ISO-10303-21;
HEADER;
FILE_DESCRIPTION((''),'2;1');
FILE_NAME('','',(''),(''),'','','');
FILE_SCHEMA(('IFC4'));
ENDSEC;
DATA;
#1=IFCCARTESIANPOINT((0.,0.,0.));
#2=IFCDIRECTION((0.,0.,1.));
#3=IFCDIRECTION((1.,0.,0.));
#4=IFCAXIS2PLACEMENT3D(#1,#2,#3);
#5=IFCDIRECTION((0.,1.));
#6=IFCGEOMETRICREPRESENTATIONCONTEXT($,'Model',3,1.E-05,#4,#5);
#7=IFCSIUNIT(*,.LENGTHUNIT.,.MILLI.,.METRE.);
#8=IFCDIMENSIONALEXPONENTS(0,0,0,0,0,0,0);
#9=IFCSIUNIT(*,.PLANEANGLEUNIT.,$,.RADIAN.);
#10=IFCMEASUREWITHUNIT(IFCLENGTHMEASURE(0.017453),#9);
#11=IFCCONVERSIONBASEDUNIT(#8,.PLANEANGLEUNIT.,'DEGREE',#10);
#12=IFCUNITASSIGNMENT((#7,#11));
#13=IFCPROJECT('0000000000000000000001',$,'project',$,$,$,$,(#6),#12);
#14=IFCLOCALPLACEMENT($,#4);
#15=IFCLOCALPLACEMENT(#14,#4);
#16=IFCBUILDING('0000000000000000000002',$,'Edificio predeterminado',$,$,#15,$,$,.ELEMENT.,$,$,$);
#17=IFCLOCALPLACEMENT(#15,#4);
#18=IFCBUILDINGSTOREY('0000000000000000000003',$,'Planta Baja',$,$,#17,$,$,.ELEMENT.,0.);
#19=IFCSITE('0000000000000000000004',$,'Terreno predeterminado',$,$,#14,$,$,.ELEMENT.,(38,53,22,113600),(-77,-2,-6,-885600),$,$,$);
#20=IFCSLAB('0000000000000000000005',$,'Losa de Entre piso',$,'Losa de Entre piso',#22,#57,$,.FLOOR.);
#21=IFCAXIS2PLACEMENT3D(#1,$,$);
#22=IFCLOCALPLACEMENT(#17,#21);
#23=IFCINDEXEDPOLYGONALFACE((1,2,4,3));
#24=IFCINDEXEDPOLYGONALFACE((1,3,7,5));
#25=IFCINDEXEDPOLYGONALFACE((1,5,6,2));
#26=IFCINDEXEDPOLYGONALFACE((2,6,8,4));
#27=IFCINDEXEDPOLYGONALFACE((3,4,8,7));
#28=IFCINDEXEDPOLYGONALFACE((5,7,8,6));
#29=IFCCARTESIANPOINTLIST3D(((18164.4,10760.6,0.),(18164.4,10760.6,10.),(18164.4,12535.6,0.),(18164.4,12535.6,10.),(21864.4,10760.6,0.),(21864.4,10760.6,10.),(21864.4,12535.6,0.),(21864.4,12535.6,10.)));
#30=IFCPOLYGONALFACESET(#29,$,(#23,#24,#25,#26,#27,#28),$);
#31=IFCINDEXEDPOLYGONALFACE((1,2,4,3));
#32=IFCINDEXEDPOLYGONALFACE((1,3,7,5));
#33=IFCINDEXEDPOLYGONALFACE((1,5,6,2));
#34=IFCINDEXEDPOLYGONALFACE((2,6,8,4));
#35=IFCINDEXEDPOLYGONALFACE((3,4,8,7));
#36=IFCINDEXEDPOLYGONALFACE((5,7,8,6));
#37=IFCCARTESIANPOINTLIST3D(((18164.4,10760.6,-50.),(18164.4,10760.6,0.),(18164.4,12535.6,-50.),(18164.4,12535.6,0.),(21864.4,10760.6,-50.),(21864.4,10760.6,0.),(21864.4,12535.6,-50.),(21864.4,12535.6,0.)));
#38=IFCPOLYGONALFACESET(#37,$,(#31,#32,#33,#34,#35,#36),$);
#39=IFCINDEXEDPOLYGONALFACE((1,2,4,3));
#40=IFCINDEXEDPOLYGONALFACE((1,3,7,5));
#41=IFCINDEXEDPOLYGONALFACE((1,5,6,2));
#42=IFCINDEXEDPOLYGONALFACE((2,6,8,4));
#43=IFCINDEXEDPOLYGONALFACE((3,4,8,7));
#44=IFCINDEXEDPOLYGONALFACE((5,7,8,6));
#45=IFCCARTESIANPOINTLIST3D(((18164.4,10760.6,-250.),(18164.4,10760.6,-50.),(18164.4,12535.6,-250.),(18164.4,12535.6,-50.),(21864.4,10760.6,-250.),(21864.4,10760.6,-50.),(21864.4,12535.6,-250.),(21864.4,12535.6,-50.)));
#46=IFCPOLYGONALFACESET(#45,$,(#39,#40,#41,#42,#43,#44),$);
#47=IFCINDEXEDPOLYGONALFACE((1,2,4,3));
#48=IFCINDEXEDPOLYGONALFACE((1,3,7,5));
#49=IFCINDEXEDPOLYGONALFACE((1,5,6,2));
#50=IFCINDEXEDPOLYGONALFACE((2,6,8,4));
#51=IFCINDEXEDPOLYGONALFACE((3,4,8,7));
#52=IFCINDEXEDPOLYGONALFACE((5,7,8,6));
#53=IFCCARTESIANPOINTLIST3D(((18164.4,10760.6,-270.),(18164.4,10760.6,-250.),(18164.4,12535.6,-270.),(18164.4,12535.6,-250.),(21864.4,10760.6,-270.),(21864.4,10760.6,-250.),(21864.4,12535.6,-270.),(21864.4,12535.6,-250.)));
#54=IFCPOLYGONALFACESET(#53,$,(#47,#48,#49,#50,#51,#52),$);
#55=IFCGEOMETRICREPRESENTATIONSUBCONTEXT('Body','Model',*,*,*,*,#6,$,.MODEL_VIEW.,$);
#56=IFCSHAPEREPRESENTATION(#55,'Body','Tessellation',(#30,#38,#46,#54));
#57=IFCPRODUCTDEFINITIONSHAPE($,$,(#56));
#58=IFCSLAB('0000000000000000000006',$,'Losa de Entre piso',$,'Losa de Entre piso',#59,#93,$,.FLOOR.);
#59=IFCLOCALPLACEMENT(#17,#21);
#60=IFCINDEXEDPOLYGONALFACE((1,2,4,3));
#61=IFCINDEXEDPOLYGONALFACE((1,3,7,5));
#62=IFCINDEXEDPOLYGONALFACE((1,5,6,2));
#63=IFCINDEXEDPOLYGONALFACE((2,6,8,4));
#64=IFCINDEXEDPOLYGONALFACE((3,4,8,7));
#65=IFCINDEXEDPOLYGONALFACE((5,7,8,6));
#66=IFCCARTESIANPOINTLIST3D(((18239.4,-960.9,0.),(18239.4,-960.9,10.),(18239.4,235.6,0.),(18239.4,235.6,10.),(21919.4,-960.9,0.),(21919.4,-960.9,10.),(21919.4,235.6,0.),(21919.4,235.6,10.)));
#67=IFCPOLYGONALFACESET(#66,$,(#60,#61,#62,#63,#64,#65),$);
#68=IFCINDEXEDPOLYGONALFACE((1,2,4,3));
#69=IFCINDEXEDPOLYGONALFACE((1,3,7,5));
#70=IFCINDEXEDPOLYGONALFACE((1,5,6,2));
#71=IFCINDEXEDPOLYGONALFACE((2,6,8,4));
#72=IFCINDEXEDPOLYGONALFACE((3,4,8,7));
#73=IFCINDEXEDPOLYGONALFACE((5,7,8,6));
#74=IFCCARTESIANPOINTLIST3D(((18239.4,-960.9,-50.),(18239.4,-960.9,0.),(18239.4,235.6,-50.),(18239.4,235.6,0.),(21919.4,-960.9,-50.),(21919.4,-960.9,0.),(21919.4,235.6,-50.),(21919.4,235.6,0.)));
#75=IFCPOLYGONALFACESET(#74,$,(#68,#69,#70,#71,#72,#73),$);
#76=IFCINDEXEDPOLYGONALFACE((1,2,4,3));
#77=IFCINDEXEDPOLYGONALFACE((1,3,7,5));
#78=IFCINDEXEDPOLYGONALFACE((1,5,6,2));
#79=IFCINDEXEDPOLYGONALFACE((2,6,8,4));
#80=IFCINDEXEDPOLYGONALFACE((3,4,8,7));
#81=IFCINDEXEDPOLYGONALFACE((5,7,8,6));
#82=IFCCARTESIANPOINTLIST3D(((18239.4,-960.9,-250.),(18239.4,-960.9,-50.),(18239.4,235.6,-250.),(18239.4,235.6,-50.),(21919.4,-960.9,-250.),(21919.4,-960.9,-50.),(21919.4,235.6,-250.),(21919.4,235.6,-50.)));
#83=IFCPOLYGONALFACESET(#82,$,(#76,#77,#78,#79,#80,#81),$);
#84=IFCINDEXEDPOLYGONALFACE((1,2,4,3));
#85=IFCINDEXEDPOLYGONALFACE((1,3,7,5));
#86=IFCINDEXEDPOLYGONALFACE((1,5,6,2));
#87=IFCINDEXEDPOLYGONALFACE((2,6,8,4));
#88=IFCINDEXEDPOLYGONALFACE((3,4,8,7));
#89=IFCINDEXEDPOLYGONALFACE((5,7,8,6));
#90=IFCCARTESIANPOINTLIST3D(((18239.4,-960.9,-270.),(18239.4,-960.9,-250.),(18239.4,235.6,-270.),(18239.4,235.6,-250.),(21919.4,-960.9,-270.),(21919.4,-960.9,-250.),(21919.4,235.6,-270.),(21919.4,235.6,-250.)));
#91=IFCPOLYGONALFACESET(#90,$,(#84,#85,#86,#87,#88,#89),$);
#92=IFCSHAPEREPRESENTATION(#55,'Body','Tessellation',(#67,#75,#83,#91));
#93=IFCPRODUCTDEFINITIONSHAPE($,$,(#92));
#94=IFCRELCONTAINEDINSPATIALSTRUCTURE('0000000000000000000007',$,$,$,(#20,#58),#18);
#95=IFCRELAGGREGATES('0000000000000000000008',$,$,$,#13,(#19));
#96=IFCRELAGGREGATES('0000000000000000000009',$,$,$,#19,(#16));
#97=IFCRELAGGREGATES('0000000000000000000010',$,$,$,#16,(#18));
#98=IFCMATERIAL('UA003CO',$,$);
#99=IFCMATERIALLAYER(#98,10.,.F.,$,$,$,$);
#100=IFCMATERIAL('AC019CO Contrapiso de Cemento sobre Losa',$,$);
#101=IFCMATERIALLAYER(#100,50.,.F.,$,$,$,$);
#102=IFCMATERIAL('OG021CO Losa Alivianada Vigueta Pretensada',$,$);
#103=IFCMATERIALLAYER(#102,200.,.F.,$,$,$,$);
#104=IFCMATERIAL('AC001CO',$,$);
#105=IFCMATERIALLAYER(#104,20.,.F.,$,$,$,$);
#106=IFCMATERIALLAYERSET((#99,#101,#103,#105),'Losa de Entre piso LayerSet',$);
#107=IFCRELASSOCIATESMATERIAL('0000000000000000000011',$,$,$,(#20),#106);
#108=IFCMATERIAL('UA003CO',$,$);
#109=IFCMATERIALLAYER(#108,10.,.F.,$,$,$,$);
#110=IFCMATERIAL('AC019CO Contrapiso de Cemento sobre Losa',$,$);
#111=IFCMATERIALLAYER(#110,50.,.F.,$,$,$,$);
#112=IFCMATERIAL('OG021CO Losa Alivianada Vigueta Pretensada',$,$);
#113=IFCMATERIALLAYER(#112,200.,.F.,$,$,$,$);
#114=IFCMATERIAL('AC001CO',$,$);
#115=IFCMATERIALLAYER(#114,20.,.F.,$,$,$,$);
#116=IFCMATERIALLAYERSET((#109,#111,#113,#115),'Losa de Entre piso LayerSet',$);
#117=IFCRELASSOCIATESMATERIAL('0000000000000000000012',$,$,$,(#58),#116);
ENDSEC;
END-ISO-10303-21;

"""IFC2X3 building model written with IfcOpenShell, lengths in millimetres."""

from ifc_helpers import new_model, entity, si_unit, converted_unit, direction, frame, origin_with_axes, place, context, subcontext, project, spatial, polyline, outline, extrude, material, layer, layer_set, layer_usage, element, save


model = new_model("IFC2X3")

# Units and contexts
model_context = context("Model", 3, precision=1e-05, world=origin_with_axes(), true_north=direction((0.0, 1.0)))
body_context = subcontext(model_context, "Body", "Model", "MODEL_VIEW")
ifc_project = project(units=[si_unit("LENGTHUNIT", "METRE", prefix="MILLI"), converted_unit("PLANEANGLEUNIT", "DEGREE", entity("IfcLengthMeasure", 0.017453), si_unit("PLANEANGLEUNIT", "RADIAN"), dimensions=[0, 0, 0, 0, 0, 0, 0])], contexts=[model_context])

# Site, building, storey
site_placement = place(None, origin_with_axes())
site = spatial("IfcSite", under=ifc_project, at=site_placement, Name="Terreno predeterminado", CompositionType="ELEMENT", RefLatitude=(38, 53, 22, 113600), RefLongitude=(-77, -2, -6, -885600))
building_placement = place(site_placement, origin_with_axes())
building = spatial("IfcBuilding", under=site, at=building_placement, Name="Edificio predeterminado", CompositionType="ELEMENT")
storey_placement = place(building_placement, origin_with_axes())
storey = spatial("IfcBuildingStorey", under=building, at=storey_placement, Name="Planta Baja", CompositionType="ELEMENT", Elevation=0.0)

# Slabs
ifc_material_1 = material(Name="UA003CO")
ifc_layer_1 = layer(ifc_material_1, 10.0, ventilated=False)
ifc_material_2 = material(Name="AC019CO Contrapiso de Cemento sobre Losa")
ifc_layer_2 = layer(ifc_material_2, 50.0, ventilated=False)
ifc_material_3 = material(Name="OG021CO Losa Alivianada Vigueta Pretensada")
ifc_layer_3 = layer(ifc_material_3, 200.0, ventilated=False)
ifc_material_4 = material(Name="AC001CO")
ifc_layer_4 = layer(ifc_material_4, 20.0, ventilated=False)
ifc_layer_set_1 = layer_set([ifc_layer_1, ifc_layer_2, ifc_layer_3, ifc_layer_4], Name="Losa de Entre piso LayerSet")
ifc_layer_usage_1 = layer_usage(ifc_layer_set_1, "AXIS3", "POSITIVE", 0.0)
slab_1_placement = place(storey_placement, origin_with_axes())
element("IfcSlab", 1, at=slab_1_placement, inside=storey, material=ifc_layer_usage_1, Name="Losa de Entre piso", ObjectType="Losa de Entre piso", PredefinedType="FLOOR", context=body_context, shape_type="SweptSolid", body=[
    extrude(outline(polyline([(0.0, 0.0), (1775.0, 0.0), (1775.0, 3700.0), (0.0, 3700.0), (0.0, 0.0)])), frame((21864.4, 12535.6, 0.0), z_axis=(0.0, 0.0, -1.0), x_axis=(0.0, -1.0, 0.0)), (0.0, 0.0, -1.0), 10.0),
    extrude(outline(polyline([(0.0, 0.0), (1775.0, 0.0), (1775.0, 3700.0), (0.0, 3700.0), (0.0, 0.0)])), frame((21864.4, 12535.6, -50.0), z_axis=(0.0, 0.0, -1.0), x_axis=(0.0, -1.0, 0.0)), (0.0, 0.0, -1.0), 50.0),
    extrude(outline(polyline([(0.0, 0.0), (1775.0, 0.0), (1775.0, 3700.0), (0.0, 3700.0), (0.0, 0.0)])), frame((21864.4, 12535.6, -250.0), z_axis=(0.0, 0.0, -1.0), x_axis=(0.0, -1.0, 0.0)), (0.0, 0.0, -1.0), 200.0),
    extrude(outline(polyline([(0.0, 0.0), (1775.0, 0.0), (1775.0, 3700.0), (0.0, 3700.0), (0.0, 0.0)])), frame((21864.4, 12535.6, -270.0), z_axis=(0.0, 0.0, -1.0), x_axis=(0.0, -1.0, 0.0)), (0.0, 0.0, -1.0), 20.0),
])
ifc_material_5 = material(Name="UA003CO")
ifc_layer_5 = layer(ifc_material_5, 10.0, ventilated=False)
ifc_material_6 = material(Name="AC019CO Contrapiso de Cemento sobre Losa")
ifc_layer_6 = layer(ifc_material_6, 50.0, ventilated=False)
ifc_material_7 = material(Name="OG021CO Losa Alivianada Vigueta Pretensada")
ifc_layer_7 = layer(ifc_material_7, 200.0, ventilated=False)
ifc_material_8 = material(Name="AC001CO")
ifc_layer_8 = layer(ifc_material_8, 20.0, ventilated=False)
ifc_layer_set_2 = layer_set([ifc_layer_5, ifc_layer_6, ifc_layer_7, ifc_layer_8], Name="Losa de Entre piso LayerSet")
ifc_layer_usage_2 = layer_usage(ifc_layer_set_2, "AXIS3", "POSITIVE", 0.0)
slab_2_placement = place(storey_placement, origin_with_axes())
element("IfcSlab", 2, at=slab_2_placement, inside=storey, material=ifc_layer_usage_2, Name="Losa de Entre piso", ObjectType="Losa de Entre piso", PredefinedType="FLOOR", context=body_context, shape_type="SweptSolid", body=[
    extrude(outline(polyline([(0.0, 0.0), (1196.6, 0.0), (1196.6, 3680.0), (0.0, 3680.0), (0.0, 0.0)])), frame((21919.4, 235.6, 0.0), z_axis=(0.0, 0.0, -1.0), x_axis=(0.0, -1.0, 0.0)), (0.0, 0.0, -1.0), 10.0),
    extrude(outline(polyline([(0.0, 0.0), (1196.6, 0.0), (1196.6, 3680.0), (0.0, 3680.0), (0.0, 0.0)])), frame((21919.4, 235.6, -50.0), z_axis=(0.0, 0.0, -1.0), x_axis=(0.0, -1.0, 0.0)), (0.0, 0.0, -1.0), 50.0),
    extrude(outline(polyline([(0.0, 0.0), (1196.6, 0.0), (1196.6, 3680.0), (0.0, 3680.0), (0.0, 0.0)])), frame((21919.4, 235.6, -250.0), z_axis=(0.0, 0.0, -1.0), x_axis=(0.0, -1.0, 0.0)), (0.0, 0.0, -1.0), 200.0),
    extrude(outline(polyline([(0.0, 0.0), (1196.6, 0.0), (1196.6, 3680.0), (0.0, 3680.0), (0.0, 0.0)])), frame((21919.4, 235.6, -270.0), z_axis=(0.0, 0.0, -1.0), x_axis=(0.0, -1.0, 0.0)), (0.0, 0.0, -1.0), 20.0),
])

save(model, "model.ifc")
